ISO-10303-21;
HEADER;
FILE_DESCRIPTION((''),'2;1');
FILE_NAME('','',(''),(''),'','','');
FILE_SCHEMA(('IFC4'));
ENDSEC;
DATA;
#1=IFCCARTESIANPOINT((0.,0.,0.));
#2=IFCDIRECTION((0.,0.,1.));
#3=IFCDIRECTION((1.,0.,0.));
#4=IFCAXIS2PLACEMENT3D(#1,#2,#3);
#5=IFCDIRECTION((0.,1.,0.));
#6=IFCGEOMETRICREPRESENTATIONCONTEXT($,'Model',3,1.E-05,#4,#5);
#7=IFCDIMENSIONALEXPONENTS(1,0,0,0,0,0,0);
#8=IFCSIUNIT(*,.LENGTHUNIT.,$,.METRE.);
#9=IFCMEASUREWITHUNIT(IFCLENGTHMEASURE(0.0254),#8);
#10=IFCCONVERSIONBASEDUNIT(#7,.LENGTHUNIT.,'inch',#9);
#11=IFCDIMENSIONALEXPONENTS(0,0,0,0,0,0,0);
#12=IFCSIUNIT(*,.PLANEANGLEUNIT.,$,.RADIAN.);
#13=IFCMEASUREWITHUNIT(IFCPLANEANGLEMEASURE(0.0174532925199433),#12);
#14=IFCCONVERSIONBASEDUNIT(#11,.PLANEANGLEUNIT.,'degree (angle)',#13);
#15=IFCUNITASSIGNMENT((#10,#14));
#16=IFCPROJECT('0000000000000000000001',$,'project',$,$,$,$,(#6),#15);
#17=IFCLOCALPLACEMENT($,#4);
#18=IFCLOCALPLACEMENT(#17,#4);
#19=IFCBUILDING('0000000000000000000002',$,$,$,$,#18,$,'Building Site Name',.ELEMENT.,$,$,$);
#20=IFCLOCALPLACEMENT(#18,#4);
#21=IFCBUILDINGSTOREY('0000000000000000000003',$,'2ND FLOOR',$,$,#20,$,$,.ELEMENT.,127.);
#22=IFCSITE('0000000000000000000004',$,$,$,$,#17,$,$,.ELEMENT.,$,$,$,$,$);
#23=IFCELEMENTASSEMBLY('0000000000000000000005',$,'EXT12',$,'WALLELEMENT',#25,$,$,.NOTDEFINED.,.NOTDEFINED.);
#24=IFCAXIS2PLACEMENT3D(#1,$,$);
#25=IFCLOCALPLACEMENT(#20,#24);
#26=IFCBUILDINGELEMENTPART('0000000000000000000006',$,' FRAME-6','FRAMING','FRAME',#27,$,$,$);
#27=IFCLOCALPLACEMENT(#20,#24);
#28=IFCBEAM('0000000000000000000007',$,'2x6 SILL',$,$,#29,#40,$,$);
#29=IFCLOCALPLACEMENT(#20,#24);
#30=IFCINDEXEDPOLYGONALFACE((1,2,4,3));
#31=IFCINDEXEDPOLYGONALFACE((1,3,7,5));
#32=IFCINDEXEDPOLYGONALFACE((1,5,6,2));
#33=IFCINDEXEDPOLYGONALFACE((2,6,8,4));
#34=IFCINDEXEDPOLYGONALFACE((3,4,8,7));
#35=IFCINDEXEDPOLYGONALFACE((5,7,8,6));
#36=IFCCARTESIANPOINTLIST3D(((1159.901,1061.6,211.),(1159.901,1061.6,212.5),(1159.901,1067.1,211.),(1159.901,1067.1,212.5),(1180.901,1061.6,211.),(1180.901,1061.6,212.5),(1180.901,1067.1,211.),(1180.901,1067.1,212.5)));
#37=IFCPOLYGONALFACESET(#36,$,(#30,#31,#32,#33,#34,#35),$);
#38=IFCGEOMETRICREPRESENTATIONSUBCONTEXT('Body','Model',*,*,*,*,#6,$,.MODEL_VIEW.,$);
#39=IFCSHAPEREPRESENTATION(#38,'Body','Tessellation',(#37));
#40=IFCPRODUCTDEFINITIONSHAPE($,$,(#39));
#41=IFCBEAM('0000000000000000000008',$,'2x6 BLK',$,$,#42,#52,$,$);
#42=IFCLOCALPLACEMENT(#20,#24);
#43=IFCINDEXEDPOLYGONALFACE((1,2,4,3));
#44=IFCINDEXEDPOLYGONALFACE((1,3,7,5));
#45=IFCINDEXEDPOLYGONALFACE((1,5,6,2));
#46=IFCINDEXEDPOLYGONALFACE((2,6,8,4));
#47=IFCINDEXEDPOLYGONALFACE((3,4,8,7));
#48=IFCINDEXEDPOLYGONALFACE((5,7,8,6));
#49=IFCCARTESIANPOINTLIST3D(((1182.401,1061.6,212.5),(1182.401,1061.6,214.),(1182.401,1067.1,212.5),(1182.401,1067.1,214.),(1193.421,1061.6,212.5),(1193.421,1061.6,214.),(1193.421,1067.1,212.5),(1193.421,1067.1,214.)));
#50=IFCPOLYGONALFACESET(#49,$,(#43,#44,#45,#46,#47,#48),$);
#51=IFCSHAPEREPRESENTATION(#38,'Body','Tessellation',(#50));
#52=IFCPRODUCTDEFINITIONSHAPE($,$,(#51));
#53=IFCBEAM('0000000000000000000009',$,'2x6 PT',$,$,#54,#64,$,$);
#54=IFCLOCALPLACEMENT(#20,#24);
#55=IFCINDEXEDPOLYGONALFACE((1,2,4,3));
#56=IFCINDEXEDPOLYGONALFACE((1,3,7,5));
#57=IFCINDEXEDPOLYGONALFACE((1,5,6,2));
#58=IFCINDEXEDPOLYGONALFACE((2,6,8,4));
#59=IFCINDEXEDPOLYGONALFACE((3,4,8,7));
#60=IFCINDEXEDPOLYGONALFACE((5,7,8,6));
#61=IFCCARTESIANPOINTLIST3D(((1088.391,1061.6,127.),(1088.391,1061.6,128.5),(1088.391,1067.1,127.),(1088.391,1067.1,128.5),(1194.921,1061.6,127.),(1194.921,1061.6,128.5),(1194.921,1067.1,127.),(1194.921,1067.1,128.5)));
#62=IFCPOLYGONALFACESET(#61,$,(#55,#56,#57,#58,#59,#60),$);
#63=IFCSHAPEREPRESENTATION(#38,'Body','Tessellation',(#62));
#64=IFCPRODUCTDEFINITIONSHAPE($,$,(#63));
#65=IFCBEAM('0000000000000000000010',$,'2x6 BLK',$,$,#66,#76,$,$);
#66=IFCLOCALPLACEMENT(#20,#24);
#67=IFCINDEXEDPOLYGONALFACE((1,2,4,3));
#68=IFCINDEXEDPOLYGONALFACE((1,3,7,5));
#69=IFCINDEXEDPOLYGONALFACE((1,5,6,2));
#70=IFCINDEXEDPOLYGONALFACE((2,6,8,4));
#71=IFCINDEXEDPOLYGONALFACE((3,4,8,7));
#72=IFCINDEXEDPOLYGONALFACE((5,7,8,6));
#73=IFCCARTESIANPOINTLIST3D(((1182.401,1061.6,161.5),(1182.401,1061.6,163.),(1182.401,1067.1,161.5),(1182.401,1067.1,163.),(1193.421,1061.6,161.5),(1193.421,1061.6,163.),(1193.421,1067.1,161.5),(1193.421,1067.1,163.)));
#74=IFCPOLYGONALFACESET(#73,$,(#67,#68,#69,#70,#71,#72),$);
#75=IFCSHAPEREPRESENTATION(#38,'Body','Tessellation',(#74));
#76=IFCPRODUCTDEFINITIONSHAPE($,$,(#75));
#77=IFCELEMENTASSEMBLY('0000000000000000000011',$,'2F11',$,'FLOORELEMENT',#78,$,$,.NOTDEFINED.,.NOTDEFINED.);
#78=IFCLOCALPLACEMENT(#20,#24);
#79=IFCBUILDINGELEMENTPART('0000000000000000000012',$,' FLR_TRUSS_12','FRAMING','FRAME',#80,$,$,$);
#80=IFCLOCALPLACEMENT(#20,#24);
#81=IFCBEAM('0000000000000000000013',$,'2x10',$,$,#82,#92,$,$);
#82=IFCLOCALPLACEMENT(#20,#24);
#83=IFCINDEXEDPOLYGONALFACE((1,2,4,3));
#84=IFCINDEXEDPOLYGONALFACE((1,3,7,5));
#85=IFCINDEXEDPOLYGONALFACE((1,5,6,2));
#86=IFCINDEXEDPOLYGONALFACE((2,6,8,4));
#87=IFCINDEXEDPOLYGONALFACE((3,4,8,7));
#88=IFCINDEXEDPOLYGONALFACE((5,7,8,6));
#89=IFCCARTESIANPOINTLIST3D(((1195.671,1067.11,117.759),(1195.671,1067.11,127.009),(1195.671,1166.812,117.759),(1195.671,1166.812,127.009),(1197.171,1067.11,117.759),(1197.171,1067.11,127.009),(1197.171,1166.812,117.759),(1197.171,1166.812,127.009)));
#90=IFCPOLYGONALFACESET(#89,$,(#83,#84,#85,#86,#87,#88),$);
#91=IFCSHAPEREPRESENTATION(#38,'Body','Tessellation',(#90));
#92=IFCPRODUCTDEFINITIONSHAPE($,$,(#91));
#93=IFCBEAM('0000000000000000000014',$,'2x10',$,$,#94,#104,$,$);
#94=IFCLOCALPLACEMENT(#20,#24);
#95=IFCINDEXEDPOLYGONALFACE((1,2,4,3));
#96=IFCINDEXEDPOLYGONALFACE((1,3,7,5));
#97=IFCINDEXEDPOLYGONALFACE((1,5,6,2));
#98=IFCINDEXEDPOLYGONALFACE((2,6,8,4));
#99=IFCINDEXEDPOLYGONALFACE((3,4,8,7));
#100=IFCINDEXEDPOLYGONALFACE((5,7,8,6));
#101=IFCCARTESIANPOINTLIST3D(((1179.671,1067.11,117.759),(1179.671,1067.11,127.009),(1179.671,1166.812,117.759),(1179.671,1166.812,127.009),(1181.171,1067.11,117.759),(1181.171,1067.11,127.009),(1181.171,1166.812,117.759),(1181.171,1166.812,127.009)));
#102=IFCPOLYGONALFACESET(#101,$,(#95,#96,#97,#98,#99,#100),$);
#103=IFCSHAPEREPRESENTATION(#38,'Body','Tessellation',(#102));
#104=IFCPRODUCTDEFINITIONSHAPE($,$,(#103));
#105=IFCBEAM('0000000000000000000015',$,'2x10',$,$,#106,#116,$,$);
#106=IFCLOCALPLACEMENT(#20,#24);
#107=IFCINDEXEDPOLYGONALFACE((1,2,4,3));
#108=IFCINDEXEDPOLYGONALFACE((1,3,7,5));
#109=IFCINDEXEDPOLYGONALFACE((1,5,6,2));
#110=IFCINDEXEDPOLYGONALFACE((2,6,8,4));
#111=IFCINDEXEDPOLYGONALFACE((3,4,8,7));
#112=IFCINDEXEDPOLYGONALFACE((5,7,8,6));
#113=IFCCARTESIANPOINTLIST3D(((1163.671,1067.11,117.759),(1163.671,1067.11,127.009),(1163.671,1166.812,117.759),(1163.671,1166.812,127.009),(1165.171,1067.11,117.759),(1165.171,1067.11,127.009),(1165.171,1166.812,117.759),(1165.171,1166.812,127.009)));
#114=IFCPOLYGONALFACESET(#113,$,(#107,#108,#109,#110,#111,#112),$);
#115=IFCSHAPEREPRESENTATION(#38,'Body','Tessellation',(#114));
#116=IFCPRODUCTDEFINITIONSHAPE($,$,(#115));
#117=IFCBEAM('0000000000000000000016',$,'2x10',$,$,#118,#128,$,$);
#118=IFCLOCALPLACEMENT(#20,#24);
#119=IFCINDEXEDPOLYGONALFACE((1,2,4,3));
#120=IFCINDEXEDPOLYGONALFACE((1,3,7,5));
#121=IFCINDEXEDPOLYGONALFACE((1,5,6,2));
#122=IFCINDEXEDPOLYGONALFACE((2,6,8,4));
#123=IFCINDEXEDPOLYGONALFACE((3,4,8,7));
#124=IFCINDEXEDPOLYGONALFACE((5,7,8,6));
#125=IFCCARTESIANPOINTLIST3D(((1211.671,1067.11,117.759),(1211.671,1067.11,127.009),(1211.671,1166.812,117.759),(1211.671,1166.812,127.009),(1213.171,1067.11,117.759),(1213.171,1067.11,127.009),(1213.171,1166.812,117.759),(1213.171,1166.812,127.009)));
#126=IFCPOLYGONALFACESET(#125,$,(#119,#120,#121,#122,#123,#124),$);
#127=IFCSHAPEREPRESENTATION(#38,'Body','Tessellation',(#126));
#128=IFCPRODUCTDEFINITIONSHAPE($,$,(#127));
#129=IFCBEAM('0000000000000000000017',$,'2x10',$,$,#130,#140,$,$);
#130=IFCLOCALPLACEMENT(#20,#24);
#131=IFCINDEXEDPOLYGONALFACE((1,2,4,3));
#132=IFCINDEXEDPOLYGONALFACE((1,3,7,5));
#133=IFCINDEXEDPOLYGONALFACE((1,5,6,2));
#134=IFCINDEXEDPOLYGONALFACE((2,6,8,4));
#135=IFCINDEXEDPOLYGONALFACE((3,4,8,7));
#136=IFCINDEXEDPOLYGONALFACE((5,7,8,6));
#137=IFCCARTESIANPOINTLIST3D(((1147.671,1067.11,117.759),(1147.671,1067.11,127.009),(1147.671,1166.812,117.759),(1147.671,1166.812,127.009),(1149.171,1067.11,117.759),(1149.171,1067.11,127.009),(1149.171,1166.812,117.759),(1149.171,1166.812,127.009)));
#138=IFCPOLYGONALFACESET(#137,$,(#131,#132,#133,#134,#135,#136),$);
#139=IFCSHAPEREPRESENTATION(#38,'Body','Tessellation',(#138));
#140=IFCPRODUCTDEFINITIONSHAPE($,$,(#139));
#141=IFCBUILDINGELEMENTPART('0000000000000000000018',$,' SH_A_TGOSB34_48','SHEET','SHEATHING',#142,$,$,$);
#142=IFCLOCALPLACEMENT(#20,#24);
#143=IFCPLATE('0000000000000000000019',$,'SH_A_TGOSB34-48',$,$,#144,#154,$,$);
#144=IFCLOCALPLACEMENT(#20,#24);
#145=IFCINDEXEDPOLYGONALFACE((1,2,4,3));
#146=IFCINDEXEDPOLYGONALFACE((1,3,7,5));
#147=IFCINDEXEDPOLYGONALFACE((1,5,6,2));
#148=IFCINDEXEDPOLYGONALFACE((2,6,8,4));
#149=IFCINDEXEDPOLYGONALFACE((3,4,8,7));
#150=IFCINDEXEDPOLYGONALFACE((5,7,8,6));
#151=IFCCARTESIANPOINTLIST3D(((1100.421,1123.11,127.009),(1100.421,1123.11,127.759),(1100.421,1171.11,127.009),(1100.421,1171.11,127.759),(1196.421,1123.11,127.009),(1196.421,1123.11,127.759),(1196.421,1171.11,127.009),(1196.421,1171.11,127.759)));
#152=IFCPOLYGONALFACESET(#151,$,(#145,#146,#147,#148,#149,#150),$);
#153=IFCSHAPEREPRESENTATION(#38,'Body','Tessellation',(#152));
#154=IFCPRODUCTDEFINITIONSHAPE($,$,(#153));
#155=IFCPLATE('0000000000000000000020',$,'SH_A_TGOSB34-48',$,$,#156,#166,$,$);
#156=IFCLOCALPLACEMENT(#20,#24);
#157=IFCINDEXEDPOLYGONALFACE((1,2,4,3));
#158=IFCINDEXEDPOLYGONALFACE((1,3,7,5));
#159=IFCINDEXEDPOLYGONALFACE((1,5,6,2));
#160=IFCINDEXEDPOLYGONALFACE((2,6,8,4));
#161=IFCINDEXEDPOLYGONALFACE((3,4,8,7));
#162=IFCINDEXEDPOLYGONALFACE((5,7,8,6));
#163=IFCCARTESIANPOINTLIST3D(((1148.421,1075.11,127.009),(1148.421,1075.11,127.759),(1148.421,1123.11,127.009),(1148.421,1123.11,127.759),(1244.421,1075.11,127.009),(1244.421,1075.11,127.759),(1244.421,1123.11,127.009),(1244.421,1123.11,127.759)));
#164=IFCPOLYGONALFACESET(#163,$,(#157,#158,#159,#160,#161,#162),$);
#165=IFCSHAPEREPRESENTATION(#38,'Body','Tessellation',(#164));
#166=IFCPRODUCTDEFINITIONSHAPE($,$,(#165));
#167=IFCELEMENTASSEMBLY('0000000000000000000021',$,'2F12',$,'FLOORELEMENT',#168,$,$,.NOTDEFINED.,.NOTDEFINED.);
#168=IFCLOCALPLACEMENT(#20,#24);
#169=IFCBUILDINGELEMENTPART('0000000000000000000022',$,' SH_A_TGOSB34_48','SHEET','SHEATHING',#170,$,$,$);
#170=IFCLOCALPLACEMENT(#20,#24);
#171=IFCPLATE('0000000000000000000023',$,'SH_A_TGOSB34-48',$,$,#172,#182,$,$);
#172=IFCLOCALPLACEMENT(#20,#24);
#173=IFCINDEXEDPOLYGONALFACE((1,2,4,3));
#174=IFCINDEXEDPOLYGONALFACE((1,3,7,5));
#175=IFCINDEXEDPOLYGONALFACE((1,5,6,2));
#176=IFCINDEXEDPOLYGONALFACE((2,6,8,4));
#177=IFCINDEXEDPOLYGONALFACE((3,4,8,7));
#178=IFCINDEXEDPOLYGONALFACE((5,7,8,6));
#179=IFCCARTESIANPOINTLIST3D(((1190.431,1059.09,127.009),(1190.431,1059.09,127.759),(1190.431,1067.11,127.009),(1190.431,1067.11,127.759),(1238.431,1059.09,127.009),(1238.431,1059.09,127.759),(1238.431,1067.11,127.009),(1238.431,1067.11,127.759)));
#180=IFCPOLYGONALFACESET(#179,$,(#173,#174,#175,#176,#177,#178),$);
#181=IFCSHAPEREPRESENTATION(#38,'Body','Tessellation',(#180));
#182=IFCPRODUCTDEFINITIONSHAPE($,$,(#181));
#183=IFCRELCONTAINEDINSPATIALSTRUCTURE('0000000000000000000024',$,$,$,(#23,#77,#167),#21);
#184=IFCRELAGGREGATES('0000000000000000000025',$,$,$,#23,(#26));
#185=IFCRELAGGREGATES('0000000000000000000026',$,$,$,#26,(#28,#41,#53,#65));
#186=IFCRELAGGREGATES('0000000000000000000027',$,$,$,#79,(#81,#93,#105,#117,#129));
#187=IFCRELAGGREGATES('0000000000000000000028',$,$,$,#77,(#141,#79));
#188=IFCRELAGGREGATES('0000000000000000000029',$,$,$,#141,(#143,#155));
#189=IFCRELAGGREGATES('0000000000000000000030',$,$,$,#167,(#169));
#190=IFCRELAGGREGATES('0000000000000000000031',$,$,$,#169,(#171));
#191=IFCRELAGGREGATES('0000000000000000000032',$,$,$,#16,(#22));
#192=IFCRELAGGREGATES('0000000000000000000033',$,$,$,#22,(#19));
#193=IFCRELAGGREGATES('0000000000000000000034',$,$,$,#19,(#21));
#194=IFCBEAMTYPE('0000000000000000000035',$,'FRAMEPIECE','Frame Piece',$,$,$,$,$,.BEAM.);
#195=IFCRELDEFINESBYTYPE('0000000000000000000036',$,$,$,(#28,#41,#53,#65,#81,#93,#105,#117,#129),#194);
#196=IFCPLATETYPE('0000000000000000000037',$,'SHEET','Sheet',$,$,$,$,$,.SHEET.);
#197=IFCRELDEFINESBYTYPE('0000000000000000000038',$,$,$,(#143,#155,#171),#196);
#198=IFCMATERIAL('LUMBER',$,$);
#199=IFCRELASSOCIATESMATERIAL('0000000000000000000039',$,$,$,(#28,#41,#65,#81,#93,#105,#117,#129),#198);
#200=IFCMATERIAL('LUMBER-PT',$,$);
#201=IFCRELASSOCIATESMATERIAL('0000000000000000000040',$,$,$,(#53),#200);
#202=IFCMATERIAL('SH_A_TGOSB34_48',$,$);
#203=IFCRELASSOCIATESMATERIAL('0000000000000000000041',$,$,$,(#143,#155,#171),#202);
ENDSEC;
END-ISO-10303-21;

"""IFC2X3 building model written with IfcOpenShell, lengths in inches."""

from ifc_helpers import new_model, entity, si_unit, converted_unit, direction, frame, frame_2d, origin_with_axes, place, context, subcontext, project, spatial, rectangle, extrude, material, type_object, element, aggregate, save


model = new_model("IFC2X3")

# Units and contexts
model_context = context("Model", 3, precision=1e-05, world=origin_with_axes(), true_north=direction((0.0, 1.0, 0.0)))
body_context = subcontext(model_context, "Body", "Model", "MODEL_VIEW")
ifc_project = project(units=[converted_unit("LENGTHUNIT", "inch", entity("IfcLengthMeasure", 0.0254), si_unit("LENGTHUNIT", "METRE"), dimensions=[1, 0, 0, 0, 0, 0, 0]), converted_unit("PLANEANGLEUNIT", "degree (angle)", entity("IfcPlaneAngleMeasure", 0.0174532925199433), si_unit("PLANEANGLEUNIT", "RADIAN"), dimensions=[0, 0, 0, 0, 0, 0, 0])], contexts=[model_context])

# Site, building, storey
site_placement = place(None, origin_with_axes())
site = spatial("IfcSite", under=ifc_project, at=site_placement, CompositionType="ELEMENT")
building_placement = place(site_placement, origin_with_axes())
building = spatial("IfcBuilding", under=site, at=building_placement, LongName="Building Site Name", CompositionType="ELEMENT")
storey_placement = place(building_placement, origin_with_axes())
storey = spatial("IfcBuildingStorey", under=building, at=storey_placement, Name="2ND FLOOR", CompositionType="ELEMENT", Elevation=127.0)

# Element assembly, building element part
ifc_material_1 = material(Name="LUMBER")
beam_type_1 = type_object("IfcBeamType", Name="FRAMEPIECE", Description="Frame Piece", PredefinedType="BEAM")
assembly_1_placement = place(storey_placement, origin_with_axes())
assembly_1 = element("IfcElementAssembly", 1, at=assembly_1_placement, inside=storey, Name="EXT12", ObjectType="WALLELEMENT", AssemblyPlace="NOTDEFINED", PredefinedType="NOTDEFINED")
building_element_part_1 = element("IfcBuildingElementPart", 2, Name=" FRAME-6", Description="FRAMING", ObjectType="FRAME")
aggregate(assembly_1, [building_element_part_1])

# Beams
beam_1_placement = place(assembly_1_placement, frame((1180.901, 1064.35, 211.75), z_axis=(-1.0, 0.0, 0.0), x_axis=(0.0, 0.0, 1.0)))
beam_1 = element("IfcBeam", 3, at=beam_1_placement, type_object=beam_type_1, material=ifc_material_1, Name="2x6 SILL", context=body_context, shape_type="SweptSolid", body=[
    extrude(rectangle(XDim=1.5, YDim=5.5, at=frame_2d((0.0, 0.0), x_axis=(-1.0, 0.0))), frame((0.0, 0.0, 0.0), z_axis=(0.0, 0.0, 1.0), x_axis=(1.0, 0.0, 0.0)), (0.0, 0.0, 1.0), 21.0),
])
beam_2_placement = place(assembly_1_placement, frame((1182.401, 1064.35, 213.25), z_axis=(1.0, 0.0, 0.0), x_axis=(0.0, 0.0, -1.0)))
beam_2 = element("IfcBeam", 4, at=beam_2_placement, type_object=beam_type_1, material=ifc_material_1, Name="2x6 BLK", context=body_context, shape_type="SweptSolid", body=[
    extrude(rectangle(XDim=1.5, YDim=5.5, at=frame_2d((0.0, 0.0), x_axis=(-1.0, 0.0))), origin_with_axes(), (0.0, 0.0, 1.0), 11.02),
])
ifc_material_2 = material(Name="LUMBER-PT")
beam_3_placement = place(assembly_1_placement, frame((1194.921, 1064.35, 127.75), z_axis=(-1.0, 0.0, 0.0), x_axis=(0.0, 0.0, 1.0)))
beam_3 = element("IfcBeam", 5, at=beam_3_placement, type_object=beam_type_1, material=ifc_material_2, Name="2x6 PT", context=body_context, shape_type="SweptSolid", body=[
    extrude(rectangle(XDim=1.5, YDim=5.5, at=frame_2d((0.0, 0.0), x_axis=(-1.0, 0.0))), frame((0.0, 0.0, 0.0), z_axis=(0.0, 0.0, 1.0), x_axis=(1.0, 0.0, 0.0)), (0.0, 0.0, 1.0), 106.53),
])
beam_4_placement = place(assembly_1_placement, frame((1182.401, 1064.35, 162.25), z_axis=(1.0, 0.0, 0.0), x_axis=(0.0, 0.0, -1.0)))
beam_4 = element("IfcBeam", 6, at=beam_4_placement, type_object=beam_type_1, material=ifc_material_1, Name="2x6 BLK", context=body_context, shape_type="SweptSolid", body=[
    extrude(rectangle(XDim=1.5, YDim=5.5, at=frame_2d((0.0, 0.0), x_axis=(-1.0, 0.0))), origin_with_axes(), (0.0, 0.0, 1.0), 11.02),
])
aggregate(building_element_part_1, [beam_1, beam_2, beam_3, beam_4])

# Element assembly, building element parts, beams, plates
assembly_2_placement = place(storey_placement, origin_with_axes())
assembly_2 = element("IfcElementAssembly", 7, at=assembly_2_placement, inside=storey, Name="2F11", ObjectType="FLOORELEMENT", AssemblyPlace="NOTDEFINED", PredefinedType="NOTDEFINED")
building_element_part_2 = element("IfcBuildingElementPart", 8, Name=" FLR_TRUSS_12", Description="FRAMING", ObjectType="FRAME")
beam_5_placement = place(assembly_2_placement, frame((1196.421, 1166.812, 122.384), z_axis=(0.0, -1.0, 0.0), x_axis=(1.0, 0.0, 0.0)))
beam_5 = element("IfcBeam", 9, at=beam_5_placement, type_object=beam_type_1, material=ifc_material_1, Name="2x10", context=body_context, shape_type="SweptSolid", body=[
    extrude(rectangle(XDim=1.5, YDim=9.25, at=frame_2d((0.0, 0.0), x_axis=(-1.0, 0.0))), origin_with_axes(), (0.0, 0.0, 1.0), 99.703),
])
beam_6_placement = place(assembly_2_placement, frame((1180.421, 1166.812, 122.384), z_axis=(0.0, -1.0, 0.0), x_axis=(1.0, 0.0, 0.0)))
beam_6 = element("IfcBeam", 10, at=beam_6_placement, type_object=beam_type_1, material=ifc_material_1, Name="2x10", context=body_context, shape_type="SweptSolid", body=[
    extrude(rectangle(XDim=1.5, YDim=9.25, at=frame_2d((0.0, 0.0), x_axis=(-1.0, 0.0))), origin_with_axes(), (0.0, 0.0, 1.0), 99.703),
])
beam_7_placement = place(assembly_2_placement, frame((1164.421, 1166.812, 122.384), z_axis=(0.0, -1.0, 0.0), x_axis=(1.0, 0.0, 0.0)))
beam_7 = element("IfcBeam", 11, at=beam_7_placement, type_object=beam_type_1, material=ifc_material_1, Name="2x10", context=body_context, shape_type="SweptSolid", body=[
    extrude(rectangle(XDim=1.5, YDim=9.25, at=frame_2d((0.0, 0.0), x_axis=(-1.0, 0.0))), origin_with_axes(), (0.0, 0.0, 1.0), 99.703),
])
beam_8_placement = place(assembly_2_placement, frame((1212.421, 1166.812, 122.384), z_axis=(0.0, -1.0, 0.0), x_axis=(1.0, 0.0, 0.0)))
beam_8 = element("IfcBeam", 12, at=beam_8_placement, type_object=beam_type_1, material=ifc_material_1, Name="2x10", context=body_context, shape_type="SweptSolid", body=[
    extrude(rectangle(XDim=1.5, YDim=9.25, at=frame_2d((0.0, 0.0), x_axis=(-1.0, 0.0))), origin_with_axes(), (0.0, 0.0, 1.0), 99.703),
])
beam_9_placement = place(assembly_2_placement, frame((1148.421, 1166.812, 122.384), z_axis=(0.0, -1.0, 0.0), x_axis=(1.0, 0.0, 0.0)))
beam_9 = element("IfcBeam", 13, at=beam_9_placement, type_object=beam_type_1, material=ifc_material_1, Name="2x10", context=body_context, shape_type="SweptSolid", body=[
    extrude(rectangle(XDim=1.5, YDim=9.25, at=frame_2d((0.0, 0.0), x_axis=(-1.0, 0.0))), origin_with_axes(), (0.0, 0.0, 1.0), 99.703),
])
aggregate(building_element_part_2, [beam_5, beam_6, beam_7, beam_8, beam_9])
building_element_part_3 = element("IfcBuildingElementPart", 14, Name=" SH_A_TGOSB34_48", Description="SHEET", ObjectType="SHEATHING")
aggregate(assembly_2, [building_element_part_3, building_element_part_2])
ifc_material_3 = material(Name="SH_A_TGOSB34_48")
plate_type = type_object("IfcPlateType", Name="SHEET", Description="Sheet", PredefinedType="SHEET")
plate_1_placement = place(assembly_2_placement, frame((1148.421, 1147.11, 127.759), z_axis=(0.0, 0.0, 1.0), x_axis=(0.0, -1.0, 0.0)))
plate_1 = element("IfcPlate", 15, at=plate_1_placement, type_object=plate_type, material=ifc_material_3, Name="SH_A_TGOSB34-48", context=body_context, shape_type="SweptSolid", body=[
    extrude(rectangle(XDim=0.75, YDim=48.0, at=frame_2d((0.0, -0.375), x_axis=(0.0, -1.0))), frame((0.0, -48.0, 0.0), z_axis=(0.0, 1.0, 0.0), x_axis=(-1.0, 0.0, 0.0)), (0.0, 0.0, 1.0), 96.0),
])
plate_2_placement = place(assembly_2_placement, frame((1196.421, 1099.11, 127.759), z_axis=(0.0, 0.0, 1.0), x_axis=(0.0, -1.0, 0.0)))
plate_2 = element("IfcPlate", 16, at=plate_2_placement, type_object=plate_type, material=ifc_material_3, Name="SH_A_TGOSB34-48", context=body_context, shape_type="SweptSolid", body=[
    extrude(rectangle(XDim=0.75, YDim=48.0, at=frame_2d((0.0, -0.375), x_axis=(0.0, -1.0))), frame((0.0, -48.0, 0.0), z_axis=(0.0, 1.0, 0.0), x_axis=(-1.0, 0.0, 0.0)), (0.0, 0.0, 1.0), 96.0),
])
aggregate(building_element_part_3, [plate_1, plate_2])

# Element assembly, building element part, plate
assembly_3_placement = place(storey_placement, origin_with_axes())
assembly_3 = element("IfcElementAssembly", 17, at=assembly_3_placement, inside=storey, Name="2F12", ObjectType="FLOORELEMENT", AssemblyPlace="NOTDEFINED", PredefinedType="NOTDEFINED")
building_element_part_4 = element("IfcBuildingElementPart", 18, Name=" SH_A_TGOSB34_48", Description="SHEET", ObjectType="SHEATHING")
aggregate(assembly_3, [building_element_part_4])
plate_3_placement = place(assembly_3_placement, frame((1214.431, 1107.09, 127.759), z_axis=(0.0, 0.0, 1.0), x_axis=(1.0, 0.0, 0.0)))
plate_3 = element("IfcPlate", 19, at=plate_3_placement, type_object=plate_type, material=ifc_material_3, Name="SH_A_TGOSB34-48", context=body_context, shape_type="SweptSolid", body=[
    extrude(rectangle(XDim=0.75, YDim=48.0, at=frame_2d((0.0, -0.375), x_axis=(0.0, -1.0))), frame((0.0, -48.0, 0.0), z_axis=(0.0, 1.0, 0.0), x_axis=(-1.0, 0.0, 0.0)), (0.0, 0.0, 1.0), 8.02),
])
aggregate(building_element_part_4, [plate_3])

save(model, "model.ifc")
